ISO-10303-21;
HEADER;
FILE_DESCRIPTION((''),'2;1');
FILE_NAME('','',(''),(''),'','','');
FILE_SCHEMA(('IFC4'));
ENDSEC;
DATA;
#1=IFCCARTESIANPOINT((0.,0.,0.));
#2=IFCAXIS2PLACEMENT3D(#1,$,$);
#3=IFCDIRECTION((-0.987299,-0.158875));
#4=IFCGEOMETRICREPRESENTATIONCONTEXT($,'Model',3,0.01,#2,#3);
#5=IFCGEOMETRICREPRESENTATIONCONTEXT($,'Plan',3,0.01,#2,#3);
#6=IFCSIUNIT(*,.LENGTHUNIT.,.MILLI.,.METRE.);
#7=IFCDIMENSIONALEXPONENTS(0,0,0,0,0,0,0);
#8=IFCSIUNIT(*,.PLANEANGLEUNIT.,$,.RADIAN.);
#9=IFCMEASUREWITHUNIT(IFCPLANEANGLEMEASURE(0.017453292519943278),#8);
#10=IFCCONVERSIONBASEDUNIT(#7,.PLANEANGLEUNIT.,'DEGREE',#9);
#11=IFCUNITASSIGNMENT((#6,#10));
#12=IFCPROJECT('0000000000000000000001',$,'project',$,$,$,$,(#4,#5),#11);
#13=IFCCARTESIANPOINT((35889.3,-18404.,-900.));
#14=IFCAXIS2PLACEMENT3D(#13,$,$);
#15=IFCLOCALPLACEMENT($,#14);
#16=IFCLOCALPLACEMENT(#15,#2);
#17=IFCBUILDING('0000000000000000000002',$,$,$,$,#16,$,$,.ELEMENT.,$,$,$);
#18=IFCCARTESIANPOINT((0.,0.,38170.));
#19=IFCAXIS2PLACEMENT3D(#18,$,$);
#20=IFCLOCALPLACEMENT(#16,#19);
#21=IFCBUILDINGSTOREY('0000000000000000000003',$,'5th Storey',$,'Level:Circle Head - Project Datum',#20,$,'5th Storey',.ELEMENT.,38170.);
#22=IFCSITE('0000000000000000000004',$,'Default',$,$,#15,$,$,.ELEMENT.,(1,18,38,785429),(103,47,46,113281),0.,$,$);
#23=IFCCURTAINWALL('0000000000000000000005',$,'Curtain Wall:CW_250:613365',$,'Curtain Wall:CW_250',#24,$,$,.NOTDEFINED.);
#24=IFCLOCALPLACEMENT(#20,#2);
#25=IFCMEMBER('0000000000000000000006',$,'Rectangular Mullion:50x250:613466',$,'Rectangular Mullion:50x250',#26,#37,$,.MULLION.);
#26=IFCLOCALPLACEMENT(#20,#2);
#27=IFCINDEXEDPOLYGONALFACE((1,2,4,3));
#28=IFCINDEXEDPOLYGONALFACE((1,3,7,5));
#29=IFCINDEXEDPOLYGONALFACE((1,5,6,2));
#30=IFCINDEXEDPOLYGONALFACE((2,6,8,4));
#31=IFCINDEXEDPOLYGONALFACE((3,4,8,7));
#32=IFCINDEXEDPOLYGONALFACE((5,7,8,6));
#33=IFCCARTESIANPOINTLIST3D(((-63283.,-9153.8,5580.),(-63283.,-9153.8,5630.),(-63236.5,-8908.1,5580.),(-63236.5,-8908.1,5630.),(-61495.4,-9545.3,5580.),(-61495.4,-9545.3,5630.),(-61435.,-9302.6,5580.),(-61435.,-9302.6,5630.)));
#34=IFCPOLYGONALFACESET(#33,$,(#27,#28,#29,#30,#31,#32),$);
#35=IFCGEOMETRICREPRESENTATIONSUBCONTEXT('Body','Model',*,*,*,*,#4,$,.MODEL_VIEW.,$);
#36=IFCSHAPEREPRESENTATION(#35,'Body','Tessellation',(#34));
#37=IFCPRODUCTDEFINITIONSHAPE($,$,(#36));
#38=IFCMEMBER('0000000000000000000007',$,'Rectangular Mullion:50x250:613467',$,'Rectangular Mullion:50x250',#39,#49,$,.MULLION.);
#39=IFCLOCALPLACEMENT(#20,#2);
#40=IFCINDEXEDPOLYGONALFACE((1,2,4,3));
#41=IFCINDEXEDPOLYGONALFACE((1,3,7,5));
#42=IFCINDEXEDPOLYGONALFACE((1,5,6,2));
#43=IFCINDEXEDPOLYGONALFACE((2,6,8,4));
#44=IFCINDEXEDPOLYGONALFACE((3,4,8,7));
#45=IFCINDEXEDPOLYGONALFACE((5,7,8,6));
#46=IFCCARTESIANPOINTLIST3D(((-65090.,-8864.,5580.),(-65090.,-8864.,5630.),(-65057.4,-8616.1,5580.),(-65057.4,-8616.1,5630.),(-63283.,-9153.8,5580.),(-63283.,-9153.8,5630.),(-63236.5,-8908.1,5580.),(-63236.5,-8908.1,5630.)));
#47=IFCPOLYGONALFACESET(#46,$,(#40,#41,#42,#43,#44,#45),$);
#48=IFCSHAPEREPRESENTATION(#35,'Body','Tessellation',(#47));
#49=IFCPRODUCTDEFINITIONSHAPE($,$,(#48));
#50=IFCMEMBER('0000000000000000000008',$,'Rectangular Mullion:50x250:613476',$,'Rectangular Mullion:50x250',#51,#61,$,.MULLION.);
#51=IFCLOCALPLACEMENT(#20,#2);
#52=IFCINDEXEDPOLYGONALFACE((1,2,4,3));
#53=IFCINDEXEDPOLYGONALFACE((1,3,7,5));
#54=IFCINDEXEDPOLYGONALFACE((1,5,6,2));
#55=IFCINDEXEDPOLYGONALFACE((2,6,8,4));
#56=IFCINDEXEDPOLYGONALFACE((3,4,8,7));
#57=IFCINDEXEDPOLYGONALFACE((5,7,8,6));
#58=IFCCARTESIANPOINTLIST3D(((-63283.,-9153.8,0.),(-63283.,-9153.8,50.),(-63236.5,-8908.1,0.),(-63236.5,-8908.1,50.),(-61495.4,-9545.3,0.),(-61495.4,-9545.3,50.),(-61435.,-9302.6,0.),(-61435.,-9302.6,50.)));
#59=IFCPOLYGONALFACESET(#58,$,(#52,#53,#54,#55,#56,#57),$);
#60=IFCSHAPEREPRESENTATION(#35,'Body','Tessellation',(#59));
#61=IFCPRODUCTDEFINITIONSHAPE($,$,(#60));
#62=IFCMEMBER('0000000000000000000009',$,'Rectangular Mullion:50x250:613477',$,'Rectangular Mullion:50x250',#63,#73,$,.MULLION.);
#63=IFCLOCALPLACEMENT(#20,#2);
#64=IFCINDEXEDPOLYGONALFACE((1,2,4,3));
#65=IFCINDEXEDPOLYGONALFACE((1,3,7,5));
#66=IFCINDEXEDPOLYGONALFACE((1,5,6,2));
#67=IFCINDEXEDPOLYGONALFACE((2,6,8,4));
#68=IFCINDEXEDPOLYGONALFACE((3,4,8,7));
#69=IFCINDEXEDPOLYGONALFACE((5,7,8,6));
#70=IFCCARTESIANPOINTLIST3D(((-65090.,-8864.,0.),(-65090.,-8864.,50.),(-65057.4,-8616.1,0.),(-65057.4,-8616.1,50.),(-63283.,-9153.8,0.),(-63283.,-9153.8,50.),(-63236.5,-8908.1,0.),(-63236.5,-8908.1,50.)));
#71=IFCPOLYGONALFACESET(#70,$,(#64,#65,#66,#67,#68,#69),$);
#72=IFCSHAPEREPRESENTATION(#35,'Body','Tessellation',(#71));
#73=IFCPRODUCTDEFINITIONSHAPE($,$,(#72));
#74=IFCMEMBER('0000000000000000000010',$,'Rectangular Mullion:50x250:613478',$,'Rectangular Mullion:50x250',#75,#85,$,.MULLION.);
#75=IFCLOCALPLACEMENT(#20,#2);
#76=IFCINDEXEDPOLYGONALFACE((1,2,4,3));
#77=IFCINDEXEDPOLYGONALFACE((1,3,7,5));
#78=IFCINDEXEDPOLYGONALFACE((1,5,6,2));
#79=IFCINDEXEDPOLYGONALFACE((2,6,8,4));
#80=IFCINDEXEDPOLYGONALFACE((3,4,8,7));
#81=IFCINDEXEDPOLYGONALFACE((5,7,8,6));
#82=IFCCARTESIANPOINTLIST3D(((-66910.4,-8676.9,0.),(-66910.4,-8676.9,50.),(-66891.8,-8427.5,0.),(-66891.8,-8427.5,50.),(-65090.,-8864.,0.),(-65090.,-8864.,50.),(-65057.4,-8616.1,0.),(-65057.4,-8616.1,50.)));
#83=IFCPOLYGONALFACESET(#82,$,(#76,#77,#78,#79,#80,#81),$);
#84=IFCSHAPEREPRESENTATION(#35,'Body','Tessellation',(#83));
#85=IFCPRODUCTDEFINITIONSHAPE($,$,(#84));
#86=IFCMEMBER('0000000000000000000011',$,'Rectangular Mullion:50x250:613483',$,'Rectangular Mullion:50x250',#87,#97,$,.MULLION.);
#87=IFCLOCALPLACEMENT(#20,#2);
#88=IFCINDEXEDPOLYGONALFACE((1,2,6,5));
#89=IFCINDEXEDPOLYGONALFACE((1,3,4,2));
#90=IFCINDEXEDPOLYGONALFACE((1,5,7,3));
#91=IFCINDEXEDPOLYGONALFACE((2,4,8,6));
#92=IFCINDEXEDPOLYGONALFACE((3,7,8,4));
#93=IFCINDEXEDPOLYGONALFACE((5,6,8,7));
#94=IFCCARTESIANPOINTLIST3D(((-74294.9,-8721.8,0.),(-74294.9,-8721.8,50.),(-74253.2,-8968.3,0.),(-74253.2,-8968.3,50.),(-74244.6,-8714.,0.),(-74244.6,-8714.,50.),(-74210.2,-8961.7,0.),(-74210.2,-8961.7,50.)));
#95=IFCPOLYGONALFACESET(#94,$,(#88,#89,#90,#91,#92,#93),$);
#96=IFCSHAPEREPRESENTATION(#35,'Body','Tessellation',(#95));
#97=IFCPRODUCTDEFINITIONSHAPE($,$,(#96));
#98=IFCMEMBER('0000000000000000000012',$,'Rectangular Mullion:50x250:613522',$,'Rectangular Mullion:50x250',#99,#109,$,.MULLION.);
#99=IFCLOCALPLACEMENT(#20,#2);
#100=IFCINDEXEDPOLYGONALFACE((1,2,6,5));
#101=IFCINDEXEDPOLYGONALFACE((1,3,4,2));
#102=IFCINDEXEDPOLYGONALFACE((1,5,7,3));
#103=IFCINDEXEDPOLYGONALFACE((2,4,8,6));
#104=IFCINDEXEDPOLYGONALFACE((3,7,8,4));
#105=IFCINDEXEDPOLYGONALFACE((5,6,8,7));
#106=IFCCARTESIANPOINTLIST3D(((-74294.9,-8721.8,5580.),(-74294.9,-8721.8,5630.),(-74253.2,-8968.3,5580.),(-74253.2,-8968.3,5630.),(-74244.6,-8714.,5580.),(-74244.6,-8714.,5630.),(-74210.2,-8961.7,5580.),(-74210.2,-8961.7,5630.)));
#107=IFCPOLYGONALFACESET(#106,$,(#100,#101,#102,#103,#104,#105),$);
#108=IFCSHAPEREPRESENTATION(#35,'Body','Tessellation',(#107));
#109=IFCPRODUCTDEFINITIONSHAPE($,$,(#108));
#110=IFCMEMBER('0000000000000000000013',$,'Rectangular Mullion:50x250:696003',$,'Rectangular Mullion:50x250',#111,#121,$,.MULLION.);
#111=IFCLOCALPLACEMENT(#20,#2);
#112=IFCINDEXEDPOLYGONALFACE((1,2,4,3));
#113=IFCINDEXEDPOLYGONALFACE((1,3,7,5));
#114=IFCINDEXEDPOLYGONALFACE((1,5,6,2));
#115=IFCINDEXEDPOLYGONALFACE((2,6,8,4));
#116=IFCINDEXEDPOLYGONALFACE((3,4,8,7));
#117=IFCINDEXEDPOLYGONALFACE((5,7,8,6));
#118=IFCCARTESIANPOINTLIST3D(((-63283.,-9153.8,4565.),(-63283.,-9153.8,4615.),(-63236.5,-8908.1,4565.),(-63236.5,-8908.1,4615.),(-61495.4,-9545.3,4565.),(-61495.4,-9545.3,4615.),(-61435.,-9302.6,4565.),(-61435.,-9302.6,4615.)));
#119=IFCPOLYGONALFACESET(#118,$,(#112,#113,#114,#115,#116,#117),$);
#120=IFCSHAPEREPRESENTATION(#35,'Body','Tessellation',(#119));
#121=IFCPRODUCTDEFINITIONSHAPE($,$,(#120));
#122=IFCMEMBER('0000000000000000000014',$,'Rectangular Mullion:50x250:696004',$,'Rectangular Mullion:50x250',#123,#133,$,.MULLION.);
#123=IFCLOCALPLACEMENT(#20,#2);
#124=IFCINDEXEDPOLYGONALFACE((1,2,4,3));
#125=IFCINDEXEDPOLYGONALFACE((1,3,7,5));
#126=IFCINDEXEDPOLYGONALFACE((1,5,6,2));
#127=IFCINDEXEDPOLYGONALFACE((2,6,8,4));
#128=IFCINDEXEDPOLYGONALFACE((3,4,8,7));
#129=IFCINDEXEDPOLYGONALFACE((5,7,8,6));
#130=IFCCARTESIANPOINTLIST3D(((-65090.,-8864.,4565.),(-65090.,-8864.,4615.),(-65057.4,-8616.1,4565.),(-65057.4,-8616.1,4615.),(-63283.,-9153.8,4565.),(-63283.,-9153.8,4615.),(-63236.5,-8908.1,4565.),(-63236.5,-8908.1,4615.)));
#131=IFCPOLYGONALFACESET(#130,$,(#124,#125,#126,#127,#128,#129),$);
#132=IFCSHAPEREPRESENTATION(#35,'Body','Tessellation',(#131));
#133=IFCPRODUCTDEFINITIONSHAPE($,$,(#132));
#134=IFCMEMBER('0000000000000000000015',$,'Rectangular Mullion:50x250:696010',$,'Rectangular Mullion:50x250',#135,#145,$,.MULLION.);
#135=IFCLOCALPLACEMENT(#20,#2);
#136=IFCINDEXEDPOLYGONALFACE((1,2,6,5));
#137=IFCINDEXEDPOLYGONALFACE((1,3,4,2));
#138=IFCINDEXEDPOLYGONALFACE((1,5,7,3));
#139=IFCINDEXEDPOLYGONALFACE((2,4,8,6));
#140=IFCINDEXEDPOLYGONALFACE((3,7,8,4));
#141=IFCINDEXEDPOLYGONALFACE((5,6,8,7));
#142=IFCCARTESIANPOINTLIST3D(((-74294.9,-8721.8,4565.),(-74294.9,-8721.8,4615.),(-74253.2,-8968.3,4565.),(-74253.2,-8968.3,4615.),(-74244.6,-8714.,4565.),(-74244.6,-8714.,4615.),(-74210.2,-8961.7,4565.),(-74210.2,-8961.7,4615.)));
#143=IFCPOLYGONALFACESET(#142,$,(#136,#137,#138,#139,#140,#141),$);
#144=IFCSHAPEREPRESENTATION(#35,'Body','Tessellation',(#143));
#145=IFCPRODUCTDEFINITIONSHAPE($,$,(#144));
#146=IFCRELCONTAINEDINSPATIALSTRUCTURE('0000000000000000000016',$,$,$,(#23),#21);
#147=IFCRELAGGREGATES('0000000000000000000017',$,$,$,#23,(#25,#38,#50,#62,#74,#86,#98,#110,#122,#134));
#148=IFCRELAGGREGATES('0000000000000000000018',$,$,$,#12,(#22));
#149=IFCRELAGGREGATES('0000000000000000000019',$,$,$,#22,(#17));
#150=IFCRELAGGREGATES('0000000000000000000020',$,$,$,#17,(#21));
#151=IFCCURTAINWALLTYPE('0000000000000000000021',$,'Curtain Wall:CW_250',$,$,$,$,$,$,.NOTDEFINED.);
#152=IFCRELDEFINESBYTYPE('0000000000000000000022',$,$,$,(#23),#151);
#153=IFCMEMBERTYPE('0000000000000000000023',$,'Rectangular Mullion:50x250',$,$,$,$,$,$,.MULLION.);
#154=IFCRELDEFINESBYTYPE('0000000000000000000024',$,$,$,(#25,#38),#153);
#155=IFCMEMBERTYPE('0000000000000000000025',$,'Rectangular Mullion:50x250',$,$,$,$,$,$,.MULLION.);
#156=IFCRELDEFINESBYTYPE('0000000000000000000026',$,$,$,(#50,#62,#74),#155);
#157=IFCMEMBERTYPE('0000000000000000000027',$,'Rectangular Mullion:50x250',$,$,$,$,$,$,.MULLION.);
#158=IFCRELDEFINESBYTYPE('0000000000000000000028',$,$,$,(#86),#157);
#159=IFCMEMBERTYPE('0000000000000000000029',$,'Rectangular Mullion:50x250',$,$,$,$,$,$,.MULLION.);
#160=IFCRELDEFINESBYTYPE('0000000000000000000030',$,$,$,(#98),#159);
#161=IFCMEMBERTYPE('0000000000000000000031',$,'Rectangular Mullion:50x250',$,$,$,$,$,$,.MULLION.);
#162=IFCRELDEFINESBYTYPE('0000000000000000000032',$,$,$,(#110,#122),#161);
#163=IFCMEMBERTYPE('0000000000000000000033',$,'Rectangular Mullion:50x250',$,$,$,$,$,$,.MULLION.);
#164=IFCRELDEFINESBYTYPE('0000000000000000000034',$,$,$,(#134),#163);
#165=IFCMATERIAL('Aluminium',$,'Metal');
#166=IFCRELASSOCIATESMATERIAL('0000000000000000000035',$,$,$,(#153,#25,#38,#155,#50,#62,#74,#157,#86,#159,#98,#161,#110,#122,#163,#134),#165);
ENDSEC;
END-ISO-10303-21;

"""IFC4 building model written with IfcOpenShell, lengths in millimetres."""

from ifc_helpers import new_model, entity, si_unit, converted_unit, direction, frame, origin, place, context, subcontext, project, spatial, indexed_curve, outline, extrude, source, transform, mapped, material, type_object, type_shapes, element, aggregate, save


model = new_model("IFC4")

# Units and contexts
model_context = context("Model", 3, precision=0.01, world=origin(), true_north=direction((-0.987299, -0.158875)))
plan_context = context("Plan", 3, precision=0.01, world=origin(), true_north=direction((-0.987299, -0.158875)))
body_context = subcontext(model_context, "Body", "Model", "MODEL_VIEW")
ifc_project = project(units=[si_unit("LENGTHUNIT", "METRE", prefix="MILLI"), converted_unit("PLANEANGLEUNIT", "DEGREE", entity("IfcPlaneAngleMeasure", 0.017453292519943278), si_unit("PLANEANGLEUNIT", "RADIAN"), dimensions=[0, 0, 0, 0, 0, 0, 0])], contexts=[model_context, plan_context])

# Site, building, storey
site_placement = place(None, frame((35889.3, -18404.0, -900.0)))
site = spatial("IfcSite", under=ifc_project, at=site_placement, Name="Default", CompositionType="ELEMENT", RefLatitude=(1, 18, 38, 785429), RefLongitude=(103, 47, 46, 113281), RefElevation=0.0)
building_placement = place(site_placement, origin())
building = spatial("IfcBuilding", under=site, at=building_placement, CompositionType="ELEMENT")
storey_placement = place(building_placement, frame((0.0, 0.0, 38170.0)))
storey = spatial("IfcBuildingStorey", under=building, at=storey_placement, Name="5th Storey", ObjectType="Level:Circle Head - Project Datum", LongName="5th Storey", CompositionType="ELEMENT", Elevation=38170.0)

# Curtain wall, members
curtain_wall_type = type_object("IfcCurtainWallType", Name="Curtain Wall:CW_250", PredefinedType="NOTDEFINED")
curtain_wall_1_placement = place(storey_placement, frame((0.0, 0.0, -38170.0)))
curtain_wall_1 = element("IfcCurtainWall", 1, at=curtain_wall_1_placement, inside=storey, type_object=curtain_wall_type, Name="Curtain Wall:CW_250:613365", ObjectType="Curtain Wall:CW_250", PredefinedType="NOTDEFINED")
ifc_material_1 = material(Name="Aluminium", Category="Metal")
member_type_1 = type_object("IfcMemberType", Name="Rectangular Mullion:50x250", PredefinedType="MULLION", material=ifc_material_1)
shared_shape_1 = source(origin(), body_context, "Body", "SweptSolid", [
    extrude(outline(indexed_curve([(-915.0, -125.0), (915.0, -125.0), (922.1, 125.0), (-922.1, 125.0), (-915.0, -125.0)], self_intersect=False)), frame((-50.0, 125.0, -915.0), z_axis=(1.0, 0.0, 0.0), x_axis=(0.0, 0.0, -1.0)), (0.0, 0.0, 1.0), 50.0),
])
type_shapes(member_type_1, [shared_shape_1])
member_1_placement = place(curtain_wall_1_placement, frame((-63283.0, -9153.8, 43800.0), z_axis=(-0.976848, 0.213934, 0.0), x_axis=(0.0, 0.0, 1.0)))
member_1 = element("IfcMember", 2, at=member_1_placement, type_object=member_type_1, material=ifc_material_1, Name="Rectangular Mullion:50x250:613466", ObjectType="Rectangular Mullion:50x250", PredefinedType="MULLION", context=body_context, shape_type="MappedRepresentation", body=[
    mapped(shared_shape_1, transform((0.0, 0.0, 0.0), scale=1.0)),
])
member_2_placement = place(curtain_wall_1_placement, frame((-65090.0, -8864.0, 43800.0), z_axis=(-0.987382, 0.158354, 0.0), x_axis=(0.0, 0.0, 1.0)))
member_2 = element("IfcMember", 3, at=member_2_placement, type_object=member_type_1, material=ifc_material_1, Name="Rectangular Mullion:50x250:613467", ObjectType="Rectangular Mullion:50x250", PredefinedType="MULLION", context=body_context, shape_type="MappedRepresentation", body=[
    mapped(shared_shape_1, transform((0.0, 0.0, 0.0), scale=1.0)),
])
member_type_2 = type_object("IfcMemberType", Name="Rectangular Mullion:50x250", PredefinedType="MULLION", material=ifc_material_1)
shared_shape_2 = source(origin(), body_context, "Body", "SweptSolid", [
    extrude(outline(indexed_curve([(-915.0, -125.0), (915.0, -125.0), (922.1, 125.0), (-922.1, 125.0), (-915.0, -125.0)], self_intersect=False)), frame((-50.0, 125.0, -915.0), z_axis=(1.0, 0.0, 0.0), x_axis=(0.0, 0.0, -1.0)), (0.0, 0.0, 1.0), 50.0),
])
type_shapes(member_type_2, [shared_shape_2])
member_3_placement = place(curtain_wall_1_placement, frame((-61495.4, -9545.3, 38170.0), z_axis=(0.976848, -0.213934, 0.0), x_axis=(0.0, 0.0, -1.0)))
member_3 = element("IfcMember", 4, at=member_3_placement, type_object=member_type_2, material=ifc_material_1, Name="Rectangular Mullion:50x250:613476", ObjectType="Rectangular Mullion:50x250", PredefinedType="MULLION", context=body_context, shape_type="MappedRepresentation", body=[
    mapped(shared_shape_2, transform((0.0, 0.0, 0.0), scale=1.0)),
])
member_4_placement = place(curtain_wall_1_placement, frame((-63283.0, -9153.8, 38170.0), z_axis=(0.987382, -0.158354, 0.0), x_axis=(0.0, 0.0, -1.0)))
member_4 = element("IfcMember", 5, at=member_4_placement, type_object=member_type_2, material=ifc_material_1, Name="Rectangular Mullion:50x250:613477", ObjectType="Rectangular Mullion:50x250", PredefinedType="MULLION", context=body_context, shape_type="MappedRepresentation", body=[
    mapped(shared_shape_2, transform((0.0, 0.0, 0.0), scale=1.0)),
])
member_5_placement = place(curtain_wall_1_placement, frame((-65090.0, -8864.0, 38170.0), z_axis=(0.994757, -0.102268, 0.0), x_axis=(0.0, 0.0, -1.0)))
member_5 = element("IfcMember", 6, at=member_5_placement, type_object=member_type_2, material=ifc_material_1, Name="Rectangular Mullion:50x250:613478", ObjectType="Rectangular Mullion:50x250", PredefinedType="MULLION", context=body_context, shape_type="MappedRepresentation", body=[
    mapped(shared_shape_2, transform((0.0, 0.0, 0.0), scale=1.0)),
])
member_type_3 = type_object("IfcMemberType", Name="Rectangular Mullion:50x250", PredefinedType="MULLION", material=ifc_material_1)
shared_shape_3 = source(origin(), body_context, "Body", "SweptSolid", [
    extrude(outline(indexed_curve([(-21.8, -125.0), (21.8, -125.0), (25.4, 125.0), (-25.4, 125.0), (-21.8, -125.0)], self_intersect=False)), frame((-50.0, 125.0, -21.8), z_axis=(1.0, 0.0, 0.0), x_axis=(0.0, 0.0, -1.0)), (0.0, 0.0, 1.0), 50.0),
])
type_shapes(member_type_3, [shared_shape_3])
member_6_placement = place(curtain_wall_1_placement, frame((-74210.2, -8961.7, 38170.0), z_axis=(0.988346, 0.152225, 0.0), x_axis=(0.0, 0.0, -1.0)))
member_6 = element("IfcMember", 7, at=member_6_placement, type_object=member_type_3, material=ifc_material_1, Name="Rectangular Mullion:50x250:613483", ObjectType="Rectangular Mullion:50x250", PredefinedType="MULLION", context=body_context, shape_type="MappedRepresentation", body=[
    mapped(shared_shape_3, transform((0.0, 0.0, 0.0), scale=1.0)),
])
member_type_4 = type_object("IfcMemberType", Name="Rectangular Mullion:50x250", PredefinedType="MULLION", material=ifc_material_1)
shared_shape_4 = source(origin(), body_context, "Body", "SweptSolid", [
    extrude(outline(indexed_curve([(-21.8, -125.0), (21.8, -125.0), (25.4, 125.0), (-25.4, 125.0), (-21.8, -125.0)], self_intersect=False)), frame((-50.0, 125.0, -21.8), z_axis=(1.0, 0.0, 0.0), x_axis=(0.0, 0.0, -1.0)), (0.0, 0.0, 1.0), 50.0),
])
type_shapes(member_type_4, [shared_shape_4])
member_7_placement = place(curtain_wall_1_placement, frame((-74253.2, -8968.3, 43800.0), z_axis=(-0.988346, -0.152225, 0.0), x_axis=(0.0, 0.0, 1.0)))
member_7 = element("IfcMember", 8, at=member_7_placement, type_object=member_type_4, material=ifc_material_1, Name="Rectangular Mullion:50x250:613522", ObjectType="Rectangular Mullion:50x250", PredefinedType="MULLION", context=body_context, shape_type="MappedRepresentation", body=[
    mapped(shared_shape_4, transform((0.0, 0.0, 0.0), scale=1.0)),
])

# Members
member_type_5 = type_object("IfcMemberType", Name="Rectangular Mullion:50x250", PredefinedType="MULLION", material=ifc_material_1)
shared_shape_5 = source(origin(), body_context, "Body", "SweptSolid", [
    extrude(outline(indexed_curve([(-915.0, -125.0), (915.0, -125.0), (922.1, 125.0), (-922.1, 125.0), (-915.0, -125.0)], self_intersect=False)), frame((-25.0, 125.0, -915.0), z_axis=(1.0, 0.0, 0.0), x_axis=(0.0, 0.0, -1.0)), (0.0, 0.0, 1.0), 50.0),
])
type_shapes(member_type_5, [shared_shape_5])
member_8_placement = place(curtain_wall_1_placement, frame((-63283.0, -9153.8, 42760.0), z_axis=(-0.976848, 0.213934, 0.0), x_axis=(0.0, 0.0, 1.0)))
member_8 = element("IfcMember", 9, at=member_8_placement, type_object=member_type_5, material=ifc_material_1, Name="Rectangular Mullion:50x250:696003", ObjectType="Rectangular Mullion:50x250", PredefinedType="MULLION", context=body_context, shape_type="MappedRepresentation", body=[
    mapped(shared_shape_5, transform((0.0, 0.0, 0.0), scale=1.0)),
])
member_9_placement = place(curtain_wall_1_placement, frame((-65090.0, -8864.0, 42760.0), z_axis=(-0.987382, 0.158354, 0.0), x_axis=(0.0, 0.0, 1.0)))
member_9 = element("IfcMember", 10, at=member_9_placement, type_object=member_type_5, material=ifc_material_1, Name="Rectangular Mullion:50x250:696004", ObjectType="Rectangular Mullion:50x250", PredefinedType="MULLION", context=body_context, shape_type="MappedRepresentation", body=[
    mapped(shared_shape_5, transform((0.0, 0.0, 0.0), scale=1.0)),
])
member_type_6 = type_object("IfcMemberType", Name="Rectangular Mullion:50x250", PredefinedType="MULLION", material=ifc_material_1)
shared_shape_6 = source(origin(), body_context, "Body", "SweptSolid", [
    extrude(outline(indexed_curve([(-21.8, -125.0), (21.8, -125.0), (25.4, 125.0), (-25.4, 125.0), (-21.8, -125.0)], self_intersect=False)), frame((-25.0, 125.0, -21.8), z_axis=(1.0, 0.0, 0.0), x_axis=(0.0, 0.0, -1.0)), (0.0, 0.0, 1.0), 50.0),
])
type_shapes(member_type_6, [shared_shape_6])
member_10_placement = place(curtain_wall_1_placement, frame((-74253.2, -8968.3, 42760.0), z_axis=(-0.988346, -0.152225, 0.0), x_axis=(0.0, 0.0, 1.0)))
member_10 = element("IfcMember", 11, at=member_10_placement, type_object=member_type_6, material=ifc_material_1, Name="Rectangular Mullion:50x250:696010", ObjectType="Rectangular Mullion:50x250", PredefinedType="MULLION", context=body_context, shape_type="MappedRepresentation", body=[
    mapped(shared_shape_6, transform((0.0, 0.0, 0.0), scale=1.0)),
])

aggregate(curtain_wall_1, [member_1, member_2, member_3, member_4, member_5, member_6, member_7, member_8, member_9, member_10])

save(model, "model.ifc")
